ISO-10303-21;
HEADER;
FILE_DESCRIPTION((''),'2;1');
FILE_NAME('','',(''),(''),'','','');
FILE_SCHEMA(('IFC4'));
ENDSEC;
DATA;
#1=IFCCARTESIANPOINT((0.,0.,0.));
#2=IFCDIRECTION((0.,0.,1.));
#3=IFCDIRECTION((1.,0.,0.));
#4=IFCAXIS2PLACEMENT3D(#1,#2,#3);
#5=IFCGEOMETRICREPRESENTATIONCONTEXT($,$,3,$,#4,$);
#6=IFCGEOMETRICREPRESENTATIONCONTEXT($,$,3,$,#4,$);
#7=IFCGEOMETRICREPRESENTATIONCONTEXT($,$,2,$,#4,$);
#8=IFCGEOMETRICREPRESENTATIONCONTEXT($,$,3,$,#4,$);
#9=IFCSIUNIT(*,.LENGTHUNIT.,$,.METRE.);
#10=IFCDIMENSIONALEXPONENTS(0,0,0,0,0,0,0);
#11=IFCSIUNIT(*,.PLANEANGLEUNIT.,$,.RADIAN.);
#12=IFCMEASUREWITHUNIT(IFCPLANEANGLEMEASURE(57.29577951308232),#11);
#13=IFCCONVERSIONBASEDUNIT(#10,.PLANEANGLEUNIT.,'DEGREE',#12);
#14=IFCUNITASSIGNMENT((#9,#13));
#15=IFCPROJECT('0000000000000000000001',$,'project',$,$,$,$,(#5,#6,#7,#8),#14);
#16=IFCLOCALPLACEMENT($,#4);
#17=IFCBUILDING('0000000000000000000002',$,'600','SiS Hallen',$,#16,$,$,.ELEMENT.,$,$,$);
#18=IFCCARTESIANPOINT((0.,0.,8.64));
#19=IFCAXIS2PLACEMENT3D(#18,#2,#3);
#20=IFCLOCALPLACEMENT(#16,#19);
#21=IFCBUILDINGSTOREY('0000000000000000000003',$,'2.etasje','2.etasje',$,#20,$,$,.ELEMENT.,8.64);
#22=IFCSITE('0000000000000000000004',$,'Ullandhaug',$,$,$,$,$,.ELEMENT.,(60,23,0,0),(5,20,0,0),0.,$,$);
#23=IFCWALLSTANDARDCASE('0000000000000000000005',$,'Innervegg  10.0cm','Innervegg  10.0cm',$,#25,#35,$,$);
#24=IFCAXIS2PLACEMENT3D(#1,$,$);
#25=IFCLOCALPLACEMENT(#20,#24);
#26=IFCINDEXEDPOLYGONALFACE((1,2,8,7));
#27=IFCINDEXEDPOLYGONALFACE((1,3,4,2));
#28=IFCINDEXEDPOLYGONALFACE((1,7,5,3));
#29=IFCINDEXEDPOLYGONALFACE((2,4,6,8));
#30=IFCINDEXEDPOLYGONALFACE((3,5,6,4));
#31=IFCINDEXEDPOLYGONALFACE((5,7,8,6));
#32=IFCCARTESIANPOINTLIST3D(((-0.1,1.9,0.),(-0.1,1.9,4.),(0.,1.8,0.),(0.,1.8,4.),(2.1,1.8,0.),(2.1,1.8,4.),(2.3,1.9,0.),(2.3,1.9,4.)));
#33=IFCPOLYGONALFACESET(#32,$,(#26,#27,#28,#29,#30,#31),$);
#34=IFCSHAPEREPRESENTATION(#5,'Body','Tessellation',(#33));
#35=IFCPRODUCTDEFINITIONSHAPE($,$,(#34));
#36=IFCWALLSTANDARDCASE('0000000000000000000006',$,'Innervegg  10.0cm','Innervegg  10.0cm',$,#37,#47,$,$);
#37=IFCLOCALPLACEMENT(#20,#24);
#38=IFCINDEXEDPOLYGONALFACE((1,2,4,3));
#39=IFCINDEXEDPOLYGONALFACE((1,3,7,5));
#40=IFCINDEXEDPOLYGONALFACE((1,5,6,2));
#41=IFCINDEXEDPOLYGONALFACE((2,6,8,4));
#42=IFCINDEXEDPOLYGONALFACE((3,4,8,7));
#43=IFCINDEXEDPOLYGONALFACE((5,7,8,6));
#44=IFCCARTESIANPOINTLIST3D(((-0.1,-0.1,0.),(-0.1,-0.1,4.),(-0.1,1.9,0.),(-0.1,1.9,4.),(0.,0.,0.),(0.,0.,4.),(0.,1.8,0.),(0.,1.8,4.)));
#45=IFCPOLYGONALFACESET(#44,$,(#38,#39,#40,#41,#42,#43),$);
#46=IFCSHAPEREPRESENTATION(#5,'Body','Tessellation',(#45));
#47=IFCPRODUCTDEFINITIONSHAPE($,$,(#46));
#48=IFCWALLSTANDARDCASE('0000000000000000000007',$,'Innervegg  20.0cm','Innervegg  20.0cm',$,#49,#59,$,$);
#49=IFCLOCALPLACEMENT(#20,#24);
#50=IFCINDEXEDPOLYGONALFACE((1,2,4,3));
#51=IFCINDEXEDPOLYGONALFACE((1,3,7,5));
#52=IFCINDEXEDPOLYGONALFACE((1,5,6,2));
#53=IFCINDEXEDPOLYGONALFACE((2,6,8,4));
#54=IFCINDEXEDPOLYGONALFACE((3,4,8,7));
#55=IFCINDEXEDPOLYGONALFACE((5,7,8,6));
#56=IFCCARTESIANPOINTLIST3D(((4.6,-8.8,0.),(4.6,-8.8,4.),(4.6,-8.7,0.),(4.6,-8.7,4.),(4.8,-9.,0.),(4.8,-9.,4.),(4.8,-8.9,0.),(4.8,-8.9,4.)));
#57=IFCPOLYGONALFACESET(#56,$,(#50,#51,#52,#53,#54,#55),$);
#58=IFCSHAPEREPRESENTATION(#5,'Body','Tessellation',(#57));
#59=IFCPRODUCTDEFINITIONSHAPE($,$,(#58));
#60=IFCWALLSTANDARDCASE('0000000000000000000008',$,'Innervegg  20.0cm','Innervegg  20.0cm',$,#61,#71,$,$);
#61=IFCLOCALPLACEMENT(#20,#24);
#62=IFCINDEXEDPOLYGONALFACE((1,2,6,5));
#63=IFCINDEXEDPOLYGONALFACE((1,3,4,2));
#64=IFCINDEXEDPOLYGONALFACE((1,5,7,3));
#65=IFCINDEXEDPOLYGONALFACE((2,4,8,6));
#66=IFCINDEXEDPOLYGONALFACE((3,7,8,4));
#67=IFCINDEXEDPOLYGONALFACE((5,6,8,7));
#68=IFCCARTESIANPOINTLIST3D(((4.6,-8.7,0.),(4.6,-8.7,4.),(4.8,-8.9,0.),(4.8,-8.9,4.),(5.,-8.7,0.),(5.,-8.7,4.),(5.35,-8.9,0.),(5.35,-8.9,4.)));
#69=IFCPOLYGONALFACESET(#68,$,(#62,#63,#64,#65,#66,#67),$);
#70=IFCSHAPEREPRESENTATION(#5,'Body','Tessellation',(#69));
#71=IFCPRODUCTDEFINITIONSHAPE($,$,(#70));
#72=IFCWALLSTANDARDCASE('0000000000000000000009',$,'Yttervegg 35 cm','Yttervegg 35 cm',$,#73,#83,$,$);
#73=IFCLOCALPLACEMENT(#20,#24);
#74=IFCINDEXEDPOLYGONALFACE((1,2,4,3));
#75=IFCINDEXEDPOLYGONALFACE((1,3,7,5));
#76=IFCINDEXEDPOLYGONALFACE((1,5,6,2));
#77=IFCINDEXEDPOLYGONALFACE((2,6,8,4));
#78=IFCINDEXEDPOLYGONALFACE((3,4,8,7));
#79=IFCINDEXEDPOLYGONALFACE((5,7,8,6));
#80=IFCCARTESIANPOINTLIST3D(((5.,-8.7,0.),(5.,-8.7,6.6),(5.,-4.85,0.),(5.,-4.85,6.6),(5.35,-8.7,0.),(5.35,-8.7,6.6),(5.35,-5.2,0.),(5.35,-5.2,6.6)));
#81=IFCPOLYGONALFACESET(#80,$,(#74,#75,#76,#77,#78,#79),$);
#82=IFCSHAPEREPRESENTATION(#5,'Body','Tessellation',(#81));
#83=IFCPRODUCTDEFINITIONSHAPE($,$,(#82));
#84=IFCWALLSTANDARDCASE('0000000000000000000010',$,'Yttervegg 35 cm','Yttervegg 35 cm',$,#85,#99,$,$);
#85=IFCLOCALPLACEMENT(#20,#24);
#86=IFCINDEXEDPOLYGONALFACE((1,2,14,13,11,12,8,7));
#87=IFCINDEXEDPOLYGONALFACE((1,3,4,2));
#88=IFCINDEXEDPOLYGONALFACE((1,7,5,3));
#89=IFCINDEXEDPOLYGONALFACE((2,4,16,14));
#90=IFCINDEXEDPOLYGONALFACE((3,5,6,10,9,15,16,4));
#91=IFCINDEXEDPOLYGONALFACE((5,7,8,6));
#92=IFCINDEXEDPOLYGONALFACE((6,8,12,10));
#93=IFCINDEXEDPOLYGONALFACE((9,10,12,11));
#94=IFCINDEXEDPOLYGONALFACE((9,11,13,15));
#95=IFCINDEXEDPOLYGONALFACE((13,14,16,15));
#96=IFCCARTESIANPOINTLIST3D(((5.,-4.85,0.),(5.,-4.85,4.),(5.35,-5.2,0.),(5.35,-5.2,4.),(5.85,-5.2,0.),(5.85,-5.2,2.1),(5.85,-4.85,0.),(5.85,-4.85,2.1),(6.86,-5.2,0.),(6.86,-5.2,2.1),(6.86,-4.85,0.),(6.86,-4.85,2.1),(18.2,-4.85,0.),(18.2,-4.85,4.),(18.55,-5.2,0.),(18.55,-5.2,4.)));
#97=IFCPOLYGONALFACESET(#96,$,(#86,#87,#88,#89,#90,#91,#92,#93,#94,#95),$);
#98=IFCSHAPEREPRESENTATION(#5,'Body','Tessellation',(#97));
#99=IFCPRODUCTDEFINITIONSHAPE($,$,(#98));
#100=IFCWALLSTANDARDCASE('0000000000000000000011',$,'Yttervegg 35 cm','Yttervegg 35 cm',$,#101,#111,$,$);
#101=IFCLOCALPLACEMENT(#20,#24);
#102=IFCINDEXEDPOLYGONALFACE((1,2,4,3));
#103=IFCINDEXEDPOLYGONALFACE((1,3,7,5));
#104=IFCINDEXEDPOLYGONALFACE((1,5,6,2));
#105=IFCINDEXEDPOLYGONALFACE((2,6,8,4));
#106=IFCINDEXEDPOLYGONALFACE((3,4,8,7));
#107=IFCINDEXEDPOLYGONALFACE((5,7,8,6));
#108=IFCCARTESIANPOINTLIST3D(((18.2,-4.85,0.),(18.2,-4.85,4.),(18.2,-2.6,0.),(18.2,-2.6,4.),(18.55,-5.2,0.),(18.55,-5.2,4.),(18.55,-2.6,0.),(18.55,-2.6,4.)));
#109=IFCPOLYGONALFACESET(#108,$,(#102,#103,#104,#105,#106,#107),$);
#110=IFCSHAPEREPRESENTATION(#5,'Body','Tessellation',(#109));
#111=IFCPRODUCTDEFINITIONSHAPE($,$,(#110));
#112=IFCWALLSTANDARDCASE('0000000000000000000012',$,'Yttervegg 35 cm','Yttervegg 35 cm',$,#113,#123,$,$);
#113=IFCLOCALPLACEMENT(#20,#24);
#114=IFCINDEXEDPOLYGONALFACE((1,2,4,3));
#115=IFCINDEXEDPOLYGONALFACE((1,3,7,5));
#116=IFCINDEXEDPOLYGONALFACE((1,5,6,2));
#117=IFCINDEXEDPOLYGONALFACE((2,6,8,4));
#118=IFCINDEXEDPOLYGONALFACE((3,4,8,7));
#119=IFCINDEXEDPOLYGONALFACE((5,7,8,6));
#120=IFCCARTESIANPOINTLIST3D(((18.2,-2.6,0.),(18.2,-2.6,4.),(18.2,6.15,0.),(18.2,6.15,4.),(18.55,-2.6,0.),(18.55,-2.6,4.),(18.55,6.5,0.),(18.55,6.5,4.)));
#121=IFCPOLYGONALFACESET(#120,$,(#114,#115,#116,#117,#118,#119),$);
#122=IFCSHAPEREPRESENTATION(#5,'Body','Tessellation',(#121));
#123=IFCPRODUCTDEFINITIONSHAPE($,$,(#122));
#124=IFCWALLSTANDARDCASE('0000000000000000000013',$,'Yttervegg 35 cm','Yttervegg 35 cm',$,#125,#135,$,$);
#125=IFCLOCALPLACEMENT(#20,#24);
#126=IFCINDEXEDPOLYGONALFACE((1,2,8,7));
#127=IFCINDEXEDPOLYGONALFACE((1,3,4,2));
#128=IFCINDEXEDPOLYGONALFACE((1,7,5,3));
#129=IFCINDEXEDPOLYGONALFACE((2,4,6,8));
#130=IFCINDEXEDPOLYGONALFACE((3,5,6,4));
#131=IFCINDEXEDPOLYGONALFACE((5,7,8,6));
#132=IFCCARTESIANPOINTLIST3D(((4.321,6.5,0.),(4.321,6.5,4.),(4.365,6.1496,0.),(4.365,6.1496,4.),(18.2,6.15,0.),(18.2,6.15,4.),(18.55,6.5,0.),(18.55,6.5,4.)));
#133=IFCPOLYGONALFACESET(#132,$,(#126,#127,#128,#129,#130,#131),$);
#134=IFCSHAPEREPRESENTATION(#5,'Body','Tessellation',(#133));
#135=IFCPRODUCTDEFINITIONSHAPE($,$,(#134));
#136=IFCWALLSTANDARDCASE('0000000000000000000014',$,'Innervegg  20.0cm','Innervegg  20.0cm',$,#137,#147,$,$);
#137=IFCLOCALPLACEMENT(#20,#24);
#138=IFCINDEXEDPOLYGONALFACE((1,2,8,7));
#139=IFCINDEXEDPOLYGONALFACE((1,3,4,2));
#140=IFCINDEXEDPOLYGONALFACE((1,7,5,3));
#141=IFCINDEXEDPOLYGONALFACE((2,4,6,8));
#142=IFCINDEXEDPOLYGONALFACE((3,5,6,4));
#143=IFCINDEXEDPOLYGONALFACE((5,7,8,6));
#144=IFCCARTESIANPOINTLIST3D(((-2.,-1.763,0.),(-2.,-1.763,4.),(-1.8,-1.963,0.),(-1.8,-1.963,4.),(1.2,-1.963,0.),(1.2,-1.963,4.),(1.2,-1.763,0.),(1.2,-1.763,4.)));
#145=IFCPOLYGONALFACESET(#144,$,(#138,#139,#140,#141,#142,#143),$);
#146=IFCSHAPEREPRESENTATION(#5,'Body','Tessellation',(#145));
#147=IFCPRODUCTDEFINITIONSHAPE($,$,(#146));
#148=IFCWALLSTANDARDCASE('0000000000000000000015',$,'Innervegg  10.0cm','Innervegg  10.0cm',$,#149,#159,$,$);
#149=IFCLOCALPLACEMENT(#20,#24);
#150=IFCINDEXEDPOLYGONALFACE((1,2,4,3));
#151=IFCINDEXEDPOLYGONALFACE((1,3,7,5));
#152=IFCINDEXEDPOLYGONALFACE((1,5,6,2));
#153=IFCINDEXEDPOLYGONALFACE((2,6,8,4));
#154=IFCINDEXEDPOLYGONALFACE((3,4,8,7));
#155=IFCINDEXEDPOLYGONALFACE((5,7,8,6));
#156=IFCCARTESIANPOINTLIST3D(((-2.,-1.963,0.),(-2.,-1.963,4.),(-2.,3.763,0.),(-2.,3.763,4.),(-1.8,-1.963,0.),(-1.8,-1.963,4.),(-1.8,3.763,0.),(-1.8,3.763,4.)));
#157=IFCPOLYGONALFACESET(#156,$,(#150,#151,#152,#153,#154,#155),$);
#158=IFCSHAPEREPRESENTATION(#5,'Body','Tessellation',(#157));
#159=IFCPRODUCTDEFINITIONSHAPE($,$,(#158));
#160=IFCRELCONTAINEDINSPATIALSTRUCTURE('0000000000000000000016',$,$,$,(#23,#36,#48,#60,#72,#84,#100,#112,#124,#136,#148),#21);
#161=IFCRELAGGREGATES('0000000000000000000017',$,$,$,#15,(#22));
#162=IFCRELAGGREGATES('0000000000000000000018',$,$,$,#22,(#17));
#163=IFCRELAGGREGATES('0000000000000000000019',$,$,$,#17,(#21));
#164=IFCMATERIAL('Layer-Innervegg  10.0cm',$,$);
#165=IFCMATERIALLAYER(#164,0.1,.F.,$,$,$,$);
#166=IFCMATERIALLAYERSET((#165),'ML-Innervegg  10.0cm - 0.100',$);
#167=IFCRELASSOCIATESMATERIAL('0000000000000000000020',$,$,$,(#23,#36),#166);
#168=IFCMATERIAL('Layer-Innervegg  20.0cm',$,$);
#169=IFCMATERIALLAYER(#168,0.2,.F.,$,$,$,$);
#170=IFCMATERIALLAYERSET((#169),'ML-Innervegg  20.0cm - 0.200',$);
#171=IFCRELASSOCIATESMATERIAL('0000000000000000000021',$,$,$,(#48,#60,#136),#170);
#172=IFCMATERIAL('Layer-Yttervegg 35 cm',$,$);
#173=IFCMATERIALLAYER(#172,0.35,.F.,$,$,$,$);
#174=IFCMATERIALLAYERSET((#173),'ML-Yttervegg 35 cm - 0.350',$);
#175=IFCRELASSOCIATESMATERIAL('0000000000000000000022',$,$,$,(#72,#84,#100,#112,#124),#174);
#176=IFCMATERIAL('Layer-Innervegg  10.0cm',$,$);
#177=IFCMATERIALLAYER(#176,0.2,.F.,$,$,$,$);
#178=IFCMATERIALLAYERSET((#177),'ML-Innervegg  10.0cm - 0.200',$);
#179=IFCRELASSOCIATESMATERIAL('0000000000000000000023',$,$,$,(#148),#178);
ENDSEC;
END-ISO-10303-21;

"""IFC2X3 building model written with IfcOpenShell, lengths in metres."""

from ifc_helpers import new_model, entity, si_unit, converted_unit, frame, origin_with_axes, place, context, project, spatial, polyline, outline, extrude, material, layer, layer_set, layer_usage, element, save


model = new_model("IFC2X3")

# Units and contexts
context_of_model_1 = context(None, 3, world=origin_with_axes())
context_of_model_2 = context(None, 3, world=origin_with_axes())
context_of_model_3 = context(None, 2, world=origin_with_axes())
context_of_model_4 = context(None, 3, world=origin_with_axes())
ifc_project = project(units=[si_unit("LENGTHUNIT", "METRE"), converted_unit("PLANEANGLEUNIT", "DEGREE", entity("IfcPlaneAngleMeasure", 57.29577951308232), si_unit("PLANEANGLEUNIT", "RADIAN"), dimensions=[0, 0, 0, 0, 0, 0, 0])], contexts=[context_of_model_1, context_of_model_2, context_of_model_3, context_of_model_4])

# Site, building, storey
site = spatial("IfcSite", under=ifc_project, Name="Ullandhaug", CompositionType="ELEMENT", RefLatitude=(60, 23, 0, 0), RefLongitude=(5, 20, 0, 0), RefElevation=0.0)
building_placement = place(None, origin_with_axes())
building = spatial("IfcBuilding", under=site, at=building_placement, Name="600", Description="SiS Hallen", CompositionType="ELEMENT")
storey_placement = place(building_placement, frame((0.0, 0.0, 8.64), z_axis=(0.0, 0.0, 1.0), x_axis=(1.0, 0.0, 0.0)))
storey = spatial("IfcBuildingStorey", under=building, at=storey_placement, Name="2.etasje", Description="2.etasje", CompositionType="ELEMENT", Elevation=8.64)

# Shared definitions
ifc_material_1 = material(Name="Layer-Yttervegg 35 cm")
ifc_layer_1 = layer(ifc_material_1, 0.35, ventilated=False)
ifc_layer_set_1 = layer_set([ifc_layer_1], Name="ML-Yttervegg 35 cm - 0.350")
ifc_layer_usage_1 = layer_usage(ifc_layer_set_1, "AXIS2", "POSITIVE", 0.0)
ifc_material_2 = material(Name="Layer-Innervegg  20.0cm")
ifc_layer_2 = layer(ifc_material_2, 0.2, ventilated=False)
ifc_layer_set_2 = layer_set([ifc_layer_2], Name="ML-Innervegg  20.0cm - 0.200")
ifc_layer_usage_2 = layer_usage(ifc_layer_set_2, "AXIS2", "POSITIVE", 0.0)

# Shared definitions
ifc_material_3 = material(Name="Layer-Innervegg  10.0cm")
ifc_layer_3 = layer(ifc_material_3, 0.1, ventilated=False)
ifc_layer_set_3 = layer_set([ifc_layer_3], Name="ML-Innervegg  10.0cm - 0.100")
ifc_layer_usage_3 = layer_usage(ifc_layer_set_3, "AXIS2", "POSITIVE", 0.0)

# Shared definitions
ifc_material_4 = material(Name="Layer-Innervegg  10.0cm")
ifc_layer_4 = layer(ifc_material_4, 0.2, ventilated=False)
ifc_layer_set_4 = layer_set([ifc_layer_4], Name="ML-Innervegg  10.0cm - 0.200")
ifc_layer_usage_4 = layer_usage(ifc_layer_set_4, "AXIS2", "POSITIVE", 0.0)

# Walls
wall_1_placement = place(storey_placement, frame((2.3, 1.9, 0.0), z_axis=(0.0, 0.0, 1.0), x_axis=(-1.0, 0.0, 0.0)))
element("IfcWallStandardCase", 1, at=wall_1_placement, inside=storey, material=ifc_layer_usage_3, Name="Innervegg  10.0cm", Description="Innervegg  10.0cm", context=context_of_model_1, shape_type="SweptSolid", body=[
    extrude(outline(polyline([(0.0, 0.0), (2.4, 0.0), (2.3, 0.1), (0.2, 0.1), (0.0, 0.0)])), frame((0.0, 0.0, 0.0), z_axis=(0.0, 0.0, 1.0), x_axis=(1.0, 0.0, 0.0)), (0.0, 0.0, 1.0), 4.0),
])
wall_2_placement = place(storey_placement, frame((-0.1, 1.9, 0.0), z_axis=(0.0, 0.0, 1.0), x_axis=(0.0, -1.0, 0.0)))
element("IfcWallStandardCase", 2, at=wall_2_placement, inside=storey, material=ifc_layer_usage_3, Name="Innervegg  10.0cm", Description="Innervegg  10.0cm", context=context_of_model_1, shape_type="SweptSolid", body=[
    extrude(outline(polyline([(0.0, 0.0), (2.0, 0.0), (1.9, 0.1), (0.1, 0.1), (0.0, 0.0)])), frame((0.0, 0.0, 0.0), z_axis=(0.0, 0.0, 1.0), x_axis=(1.0, 0.0, 0.0)), (0.0, 0.0, 1.0), 4.0),
])
wall_3_placement = place(storey_placement, frame((4.8, -9.0, 0.0), z_axis=(0.0, 0.0, 1.0), x_axis=(0.0, 1.0, 0.0)))
element("IfcWallStandardCase", 3, at=wall_3_placement, inside=storey, material=ifc_layer_usage_2, Name="Innervegg  20.0cm", Description="Innervegg  20.0cm", context=context_of_model_1, shape_type="SweptSolid", body=[
    extrude(outline(polyline([(0.0, 0.0), (0.1, 0.0), (0.3, 0.2), (0.2, 0.2), (0.0, 0.0)])), frame((0.0, 0.0, 0.0), z_axis=(0.0, 0.0, 1.0), x_axis=(1.0, 0.0, 0.0)), (0.0, 0.0, 1.0), 4.0),
])
wall_4_placement = place(storey_placement, frame((4.8, -8.9, 0.0), z_axis=(0.0, 0.0, 1.0), x_axis=(1.0, 0.0, 0.0)))
element("IfcWallStandardCase", 4, at=wall_4_placement, inside=storey, material=ifc_layer_usage_2, Name="Innervegg  20.0cm", Description="Innervegg  20.0cm", context=context_of_model_1, shape_type="SweptSolid", body=[
    extrude(outline(polyline([(0.0, 0.0), (0.55, 0.0), (0.2, 0.2), (-0.2, 0.2), (0.0, 0.0)])), origin_with_axes(), (0.0, 0.0, 1.0), 4.0),
])
wall_5_placement = place(storey_placement, frame((5.35, -8.7, 0.0), z_axis=(0.0, 0.0, 1.0), x_axis=(0.0, 1.0, 0.0)))
element("IfcWallStandardCase", 5, at=wall_5_placement, inside=storey, material=ifc_layer_usage_1, Name="Yttervegg 35 cm", Description="Yttervegg 35 cm", context=context_of_model_1, shape_type="SweptSolid", body=[
    extrude(outline(polyline([(0.0, 0.0), (3.5, 0.0), (3.85, 0.35), (0.0, 0.35), (0.0, 0.0)])), frame((0.0, 0.0, 0.0), z_axis=(0.0, 0.0, 1.0), x_axis=(1.0, 0.0, 0.0)), (0.0, 0.0, 1.0), 6.6),
])

# Wall, opening
wall_6_placement = place(storey_placement, frame((5.35, -5.2, 0.0), z_axis=(0.0, 0.0, 1.0), x_axis=(1.0, 0.0, 0.0)))
wall_6 = element("IfcWallStandardCase", 6, at=wall_6_placement, inside=storey, material=ifc_layer_usage_1, Name="Yttervegg 35 cm", Description="Yttervegg 35 cm", context=context_of_model_1, shape_type="SweptSolid", body=[
    extrude(outline(polyline([(0.0, 0.0), (13.2, 0.0), (12.85, 0.35), (-0.35, 0.35), (0.0, 0.0)])), origin_with_axes(), (0.0, 0.0, 1.0), 4.0),
])
opening_1_placement = place(wall_6_placement, frame((0.5, 0.35, 0.0), z_axis=(0.0, 0.0, 1.0), x_axis=(1.0, 0.0, 0.0)))
element("IfcOpeningElement", 7, at=opening_1_placement, cuts=wall_6, context=context_of_model_1, shape_type="SweptSolid", body=[
    extrude(outline(polyline([(0.0, 0.0), (2.1, 0.0), (2.1, 1.01), (0.0, 1.01), (0.0, 0.0)])), frame((0.0, 0.0, 0.0), z_axis=(0.0, 1.0, 0.0), x_axis=(0.0, 0.0, 1.0)), (0.0, 0.0, -1.0), 0.35),
])

# Walls
wall_7_placement = place(storey_placement, frame((18.55, -5.2, 0.0), z_axis=(0.0, 0.0, 1.0), x_axis=(0.0, 1.0, 0.0)))
element("IfcWallStandardCase", 8, at=wall_7_placement, inside=storey, material=ifc_layer_usage_1, Name="Yttervegg 35 cm", Description="Yttervegg 35 cm", context=context_of_model_1, shape_type="SweptSolid", body=[
    extrude(outline(polyline([(0.0, 0.0), (2.6, 0.0), (2.6, 0.35), (0.35, 0.35), (0.0, 0.0)])), frame((0.0, 0.0, 0.0), z_axis=(0.0, 0.0, 1.0), x_axis=(1.0, 0.0, 0.0)), (0.0, 0.0, 1.0), 4.0),
])
wall_8_placement = place(storey_placement, frame((18.55, -2.6, 0.0), z_axis=(0.0, 0.0, 1.0), x_axis=(0.0, 1.0, 0.0)))
element("IfcWallStandardCase", 9, at=wall_8_placement, inside=storey, material=ifc_layer_usage_1, Name="Yttervegg 35 cm", Description="Yttervegg 35 cm", context=context_of_model_1, shape_type="SweptSolid", body=[
    extrude(outline(polyline([(0.0, 0.0), (9.1, 0.0), (8.75, 0.35), (0.0, 0.35), (0.0, 0.0)])), frame((0.0, 0.0, 0.0), z_axis=(0.0, 0.0, 1.0), x_axis=(1.0, 0.0, 0.0)), (0.0, 0.0, 1.0), 4.0),
])
wall_9_placement = place(storey_placement, frame((18.55, 6.5, 0.0), z_axis=(0.0, 0.0, 1.0), x_axis=(-1.0, 0.0, 0.0)))
element("IfcWallStandardCase", 10, at=wall_9_placement, inside=storey, material=ifc_layer_usage_1, Name="Yttervegg 35 cm", Description="Yttervegg 35 cm", context=context_of_model_1, shape_type="SweptSolid", body=[
    extrude(outline(polyline([(0.0, 0.0), (14.229, 0.0), (14.185, 0.3504), (0.35, 0.35), (0.0, 0.0)])), frame((0.0, 0.0, 0.0), z_axis=(0.0, 0.0, 1.0), x_axis=(1.0, 0.0, 0.0)), (0.0, 0.0, 1.0), 4.0),
])
wall_10_placement = place(storey_placement, frame((1.2, -1.763, 0.0), z_axis=(0.0, 0.0, 1.0), x_axis=(-1.0, 0.0, 0.0)))
element("IfcWallStandardCase", 11, at=wall_10_placement, inside=storey, material=ifc_layer_usage_2, Name="Innervegg  20.0cm", Description="Innervegg  20.0cm", context=context_of_model_1, shape_type="SweptSolid", body=[
    extrude(outline(polyline([(0.0, 0.0), (3.2, 0.0), (3.0, 0.2), (0.0, 0.2), (0.0, 0.0)])), frame((0.0, 0.0, 0.0), z_axis=(0.0, 0.0, 1.0), x_axis=(1.0, 0.0, 0.0)), (0.0, 0.0, 1.0), 4.0),
])
wall_11_placement = place(storey_placement, frame((-1.8, -1.963, 0.0), z_axis=(0.0, 0.0, 1.0), x_axis=(0.0, 1.0, 0.0)))
element("IfcWallStandardCase", 12, at=wall_11_placement, inside=storey, material=ifc_layer_usage_4, Name="Innervegg  10.0cm", Description="Innervegg  10.0cm", context=context_of_model_1, shape_type="SweptSolid", body=[
    extrude(outline(polyline([(0.0, 0.0), (5.726, 0.0), (5.726, 0.2), (0.0, 0.2), (0.0, 0.0)])), frame((0.0, 0.0, 0.0), z_axis=(0.0, 0.0, 1.0), x_axis=(1.0, 0.0, 0.0)), (0.0, 0.0, 1.0), 4.0),
])

save(model, "model.ifc")
